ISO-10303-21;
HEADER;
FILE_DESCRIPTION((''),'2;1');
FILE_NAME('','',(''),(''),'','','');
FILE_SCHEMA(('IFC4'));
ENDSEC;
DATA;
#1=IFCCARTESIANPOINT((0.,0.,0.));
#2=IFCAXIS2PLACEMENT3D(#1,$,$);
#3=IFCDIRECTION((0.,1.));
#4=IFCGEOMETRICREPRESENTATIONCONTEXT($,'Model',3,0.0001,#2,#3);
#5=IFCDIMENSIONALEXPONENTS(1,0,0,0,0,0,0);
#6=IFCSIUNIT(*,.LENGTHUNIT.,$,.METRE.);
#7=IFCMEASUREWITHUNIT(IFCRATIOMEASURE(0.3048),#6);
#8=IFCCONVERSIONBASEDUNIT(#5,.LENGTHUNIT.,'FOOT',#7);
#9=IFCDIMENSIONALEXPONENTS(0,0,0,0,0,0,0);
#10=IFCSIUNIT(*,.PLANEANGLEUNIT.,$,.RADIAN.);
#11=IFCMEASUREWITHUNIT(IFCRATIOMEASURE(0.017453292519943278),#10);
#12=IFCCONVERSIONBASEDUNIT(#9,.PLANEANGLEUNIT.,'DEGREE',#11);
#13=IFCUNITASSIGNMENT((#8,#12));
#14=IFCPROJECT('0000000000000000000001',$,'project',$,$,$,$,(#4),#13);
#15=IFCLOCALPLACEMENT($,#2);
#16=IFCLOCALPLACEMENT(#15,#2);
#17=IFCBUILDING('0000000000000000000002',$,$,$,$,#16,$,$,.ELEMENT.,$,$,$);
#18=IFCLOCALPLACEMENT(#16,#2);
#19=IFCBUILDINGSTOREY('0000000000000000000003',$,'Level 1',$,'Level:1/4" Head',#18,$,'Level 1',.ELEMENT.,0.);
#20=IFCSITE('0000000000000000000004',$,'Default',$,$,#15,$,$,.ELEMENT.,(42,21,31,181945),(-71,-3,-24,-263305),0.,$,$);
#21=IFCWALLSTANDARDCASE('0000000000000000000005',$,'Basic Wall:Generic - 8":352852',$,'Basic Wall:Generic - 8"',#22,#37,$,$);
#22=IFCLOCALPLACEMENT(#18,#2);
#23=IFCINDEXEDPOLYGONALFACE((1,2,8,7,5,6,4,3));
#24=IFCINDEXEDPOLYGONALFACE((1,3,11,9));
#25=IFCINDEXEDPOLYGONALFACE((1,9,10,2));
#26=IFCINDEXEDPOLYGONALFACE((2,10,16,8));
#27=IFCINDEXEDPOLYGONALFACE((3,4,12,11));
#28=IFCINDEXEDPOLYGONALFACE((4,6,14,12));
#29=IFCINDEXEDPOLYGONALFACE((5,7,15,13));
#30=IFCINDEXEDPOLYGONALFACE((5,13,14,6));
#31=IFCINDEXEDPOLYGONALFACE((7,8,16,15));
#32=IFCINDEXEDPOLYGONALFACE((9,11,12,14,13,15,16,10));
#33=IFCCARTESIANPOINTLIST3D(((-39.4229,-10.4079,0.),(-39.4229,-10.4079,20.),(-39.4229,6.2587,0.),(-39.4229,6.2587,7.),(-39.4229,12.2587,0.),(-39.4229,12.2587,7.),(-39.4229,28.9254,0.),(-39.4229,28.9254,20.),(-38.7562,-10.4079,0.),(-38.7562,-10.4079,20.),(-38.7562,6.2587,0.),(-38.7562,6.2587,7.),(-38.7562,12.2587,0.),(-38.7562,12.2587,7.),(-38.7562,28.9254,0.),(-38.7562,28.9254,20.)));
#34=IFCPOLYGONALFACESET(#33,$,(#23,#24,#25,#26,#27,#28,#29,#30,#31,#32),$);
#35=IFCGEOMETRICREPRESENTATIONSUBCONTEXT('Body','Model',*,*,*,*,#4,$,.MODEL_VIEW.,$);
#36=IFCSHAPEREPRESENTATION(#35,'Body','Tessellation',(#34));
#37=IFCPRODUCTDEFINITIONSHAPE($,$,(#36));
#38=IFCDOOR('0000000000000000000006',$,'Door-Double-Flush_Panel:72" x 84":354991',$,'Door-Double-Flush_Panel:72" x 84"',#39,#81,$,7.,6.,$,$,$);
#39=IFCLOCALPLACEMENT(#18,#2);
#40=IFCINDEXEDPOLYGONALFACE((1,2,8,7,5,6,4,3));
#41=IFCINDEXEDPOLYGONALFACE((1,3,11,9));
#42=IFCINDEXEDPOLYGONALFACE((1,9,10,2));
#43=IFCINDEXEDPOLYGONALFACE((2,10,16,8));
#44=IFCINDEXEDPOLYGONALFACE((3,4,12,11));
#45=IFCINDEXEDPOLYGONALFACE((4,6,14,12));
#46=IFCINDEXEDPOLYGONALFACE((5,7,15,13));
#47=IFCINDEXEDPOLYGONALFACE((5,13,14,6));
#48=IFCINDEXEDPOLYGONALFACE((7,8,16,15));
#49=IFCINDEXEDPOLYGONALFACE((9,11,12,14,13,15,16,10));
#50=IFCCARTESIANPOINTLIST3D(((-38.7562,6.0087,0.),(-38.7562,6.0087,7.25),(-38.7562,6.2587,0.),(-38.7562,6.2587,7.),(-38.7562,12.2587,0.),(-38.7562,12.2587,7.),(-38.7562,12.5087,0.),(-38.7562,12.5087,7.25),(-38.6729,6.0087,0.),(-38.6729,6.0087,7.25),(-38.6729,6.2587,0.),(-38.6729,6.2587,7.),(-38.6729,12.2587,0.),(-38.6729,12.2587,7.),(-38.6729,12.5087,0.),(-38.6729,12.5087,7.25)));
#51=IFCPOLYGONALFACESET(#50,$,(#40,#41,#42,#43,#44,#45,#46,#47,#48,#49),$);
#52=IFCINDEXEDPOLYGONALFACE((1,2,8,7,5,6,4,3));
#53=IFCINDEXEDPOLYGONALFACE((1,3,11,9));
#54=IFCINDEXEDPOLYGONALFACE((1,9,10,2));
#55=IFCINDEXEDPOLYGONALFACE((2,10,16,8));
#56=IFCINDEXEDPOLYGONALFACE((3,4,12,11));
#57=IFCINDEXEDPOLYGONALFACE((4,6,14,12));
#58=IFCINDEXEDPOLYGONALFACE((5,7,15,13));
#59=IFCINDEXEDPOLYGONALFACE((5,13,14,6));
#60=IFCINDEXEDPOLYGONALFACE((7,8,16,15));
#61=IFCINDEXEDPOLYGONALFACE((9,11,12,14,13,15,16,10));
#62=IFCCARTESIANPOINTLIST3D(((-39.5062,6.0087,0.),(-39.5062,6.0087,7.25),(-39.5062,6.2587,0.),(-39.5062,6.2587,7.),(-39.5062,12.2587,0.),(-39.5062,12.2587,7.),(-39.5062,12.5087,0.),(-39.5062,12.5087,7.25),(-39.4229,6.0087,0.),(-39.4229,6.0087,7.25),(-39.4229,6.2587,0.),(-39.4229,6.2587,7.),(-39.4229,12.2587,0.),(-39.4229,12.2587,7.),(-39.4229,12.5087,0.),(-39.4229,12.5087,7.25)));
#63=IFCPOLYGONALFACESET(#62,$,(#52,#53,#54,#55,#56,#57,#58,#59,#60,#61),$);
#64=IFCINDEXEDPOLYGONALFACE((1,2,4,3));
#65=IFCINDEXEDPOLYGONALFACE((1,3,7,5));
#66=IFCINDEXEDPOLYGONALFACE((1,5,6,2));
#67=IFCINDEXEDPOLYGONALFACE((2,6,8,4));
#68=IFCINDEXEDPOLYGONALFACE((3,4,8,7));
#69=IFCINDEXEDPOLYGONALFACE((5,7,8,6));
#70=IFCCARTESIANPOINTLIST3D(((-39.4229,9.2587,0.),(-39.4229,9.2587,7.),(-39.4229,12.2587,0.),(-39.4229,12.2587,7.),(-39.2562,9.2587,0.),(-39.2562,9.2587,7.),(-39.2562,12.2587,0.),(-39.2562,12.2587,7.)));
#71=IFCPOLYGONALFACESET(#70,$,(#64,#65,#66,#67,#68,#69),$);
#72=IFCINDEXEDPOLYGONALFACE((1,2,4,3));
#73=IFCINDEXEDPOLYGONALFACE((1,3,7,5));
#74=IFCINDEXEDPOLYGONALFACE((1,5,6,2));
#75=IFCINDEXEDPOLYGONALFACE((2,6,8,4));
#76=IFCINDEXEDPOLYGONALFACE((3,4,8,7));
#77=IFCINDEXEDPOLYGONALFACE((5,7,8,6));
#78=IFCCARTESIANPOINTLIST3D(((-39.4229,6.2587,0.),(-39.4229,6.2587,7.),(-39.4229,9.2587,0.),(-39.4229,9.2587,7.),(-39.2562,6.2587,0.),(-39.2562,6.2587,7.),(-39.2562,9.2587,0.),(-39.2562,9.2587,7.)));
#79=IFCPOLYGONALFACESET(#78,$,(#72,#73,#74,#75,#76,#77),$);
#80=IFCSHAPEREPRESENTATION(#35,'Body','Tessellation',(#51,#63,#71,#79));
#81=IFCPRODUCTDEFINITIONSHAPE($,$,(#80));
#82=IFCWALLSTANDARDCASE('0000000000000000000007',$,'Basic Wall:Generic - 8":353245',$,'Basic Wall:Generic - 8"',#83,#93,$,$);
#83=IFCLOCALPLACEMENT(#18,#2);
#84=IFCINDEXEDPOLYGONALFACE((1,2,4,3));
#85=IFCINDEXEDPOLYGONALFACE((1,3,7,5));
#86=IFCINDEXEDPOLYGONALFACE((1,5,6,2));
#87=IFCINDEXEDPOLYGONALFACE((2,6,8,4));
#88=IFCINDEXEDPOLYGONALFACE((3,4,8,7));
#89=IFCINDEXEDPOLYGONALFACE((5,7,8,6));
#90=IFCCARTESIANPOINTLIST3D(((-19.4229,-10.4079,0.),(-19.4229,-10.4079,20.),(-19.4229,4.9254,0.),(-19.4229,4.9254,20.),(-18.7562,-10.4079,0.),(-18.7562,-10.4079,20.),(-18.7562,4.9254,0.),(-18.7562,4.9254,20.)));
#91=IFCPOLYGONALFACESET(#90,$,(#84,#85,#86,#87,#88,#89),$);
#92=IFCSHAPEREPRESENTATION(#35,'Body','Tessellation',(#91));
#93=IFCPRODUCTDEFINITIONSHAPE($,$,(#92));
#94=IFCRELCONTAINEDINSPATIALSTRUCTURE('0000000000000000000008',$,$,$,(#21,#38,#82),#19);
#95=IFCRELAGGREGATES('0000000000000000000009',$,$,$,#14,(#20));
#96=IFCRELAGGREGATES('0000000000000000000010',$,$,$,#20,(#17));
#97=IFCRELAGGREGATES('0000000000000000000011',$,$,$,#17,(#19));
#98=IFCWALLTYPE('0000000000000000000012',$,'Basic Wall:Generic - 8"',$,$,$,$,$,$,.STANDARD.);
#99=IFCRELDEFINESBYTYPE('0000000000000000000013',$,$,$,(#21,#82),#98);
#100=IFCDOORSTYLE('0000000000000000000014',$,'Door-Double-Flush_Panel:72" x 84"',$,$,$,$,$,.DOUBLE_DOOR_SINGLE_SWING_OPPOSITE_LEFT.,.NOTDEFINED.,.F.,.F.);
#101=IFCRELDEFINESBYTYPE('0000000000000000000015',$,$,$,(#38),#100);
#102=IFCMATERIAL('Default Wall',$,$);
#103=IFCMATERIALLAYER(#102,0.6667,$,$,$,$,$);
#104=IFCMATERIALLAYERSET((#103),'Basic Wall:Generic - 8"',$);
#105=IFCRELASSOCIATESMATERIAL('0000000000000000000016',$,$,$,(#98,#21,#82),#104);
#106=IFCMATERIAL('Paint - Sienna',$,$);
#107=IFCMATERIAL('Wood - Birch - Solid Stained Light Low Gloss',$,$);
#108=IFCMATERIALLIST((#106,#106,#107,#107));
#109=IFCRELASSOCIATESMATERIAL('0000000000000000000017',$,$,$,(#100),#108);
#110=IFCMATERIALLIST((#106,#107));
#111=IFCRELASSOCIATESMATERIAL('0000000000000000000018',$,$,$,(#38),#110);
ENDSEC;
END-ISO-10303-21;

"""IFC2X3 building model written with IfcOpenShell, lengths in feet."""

from ifc_helpers import new_model, entity, si_unit, converted_unit, direction, frame, frame_2d, origin, place, context, subcontext, project, spatial, polyline, rectangle, outline, extrude, source, transform, mapped, material, material_list, layer, layer_set, layer_usage, type_object, type_shapes, element, fill, save


model = new_model("IFC2X3")

# Units and contexts
model_context = context("Model", 3, precision=0.0001, world=origin(), true_north=direction((0.0, 1.0)))
body_context = subcontext(model_context, "Body", "Model", "MODEL_VIEW")
ifc_project = project(units=[converted_unit("LENGTHUNIT", "FOOT", entity("IfcRatioMeasure", 0.3048), si_unit("LENGTHUNIT", "METRE"), dimensions=[1, 0, 0, 0, 0, 0, 0]), converted_unit("PLANEANGLEUNIT", "DEGREE", entity("IfcRatioMeasure", 0.017453292519943278), si_unit("PLANEANGLEUNIT", "RADIAN"), dimensions=[0, 0, 0, 0, 0, 0, 0])], contexts=[model_context])

# Site, building, storey
site_placement = place(None, origin())
site = spatial("IfcSite", under=ifc_project, at=site_placement, Name="Default", CompositionType="ELEMENT", RefLatitude=(42, 21, 31, 181945), RefLongitude=(-71, -3, -24, -263305), RefElevation=0.0)
building_placement = place(site_placement, origin())
building = spatial("IfcBuilding", under=site, at=building_placement, CompositionType="ELEMENT")
storey_placement = place(building_placement, origin())
storey = spatial("IfcBuildingStorey", under=building, at=storey_placement, Name="Level 1", ObjectType="Level:1/4\" Head", LongName="Level 1", CompositionType="ELEMENT", Elevation=0.0)

# Shared definitions
ifc_material_1 = material(Name="Default Wall")
ifc_layer = layer(ifc_material_1, 0.6667)
ifc_layer_set = layer_set([ifc_layer], Name="Basic Wall:Generic - 8\"")
wall_type = type_object("IfcWallType", Name="Basic Wall:Generic - 8\"", PredefinedType="STANDARD", material=ifc_layer_set)

# Wall, opening, door
ifc_layer_usage_1 = layer_usage(ifc_layer_set, "AXIS2", "NEGATIVE", 0.3333)
wall_1_placement = place(storey_placement, frame((-39.0895, -10.4079, 0.0), z_axis=(0.0, 0.0, 1.0), x_axis=(0.0, 1.0, 0.0)))
wall_1 = element("IfcWallStandardCase", 1, at=wall_1_placement, inside=storey, type_object=wall_type, material=ifc_layer_usage_1, Name="Basic Wall:Generic - 8\":352852", ObjectType="Basic Wall:Generic - 8\"", context=body_context, shape_type="SweptSolid", body=[
    extrude(rectangle(XDim=39.3333, YDim=0.6667, at=frame_2d((19.6667, 0.0), x_axis=(1.0, 0.0))), origin(), (0.0, 0.0, 1.0), 20.0),
])
opening_1_placement = place(wall_1_placement, frame((16.6667, -0.3333, 0.0)))
opening_1 = element("IfcOpeningElement", 2, at=opening_1_placement, cuts=wall_1, ObjectType="Opening", context=body_context, shape_type="SweptSolid", body=[
    extrude(rectangle(XDim=7.0, YDim=6.0, at=frame_2d((3.5, 3.0), x_axis=(1.0, 0.0))), frame((0.0, 0.0, 0.0), z_axis=(0.0, 1.0, 0.0), x_axis=(0.0, 0.0, 1.0)), (0.0, 0.0, 1.0), 0.6667),
])
ifc_material_2 = material(Name="Paint - Sienna")
ifc_material_3 = material(Name="Wood - Birch - Solid Stained Light Low Gloss")
ifc_material_list_1 = material_list([ifc_material_2, ifc_material_3])
ifc_material_list_2 = material_list([ifc_material_2, ifc_material_2, ifc_material_3, ifc_material_3])
door_style_1 = type_object("IfcDoorStyle", Name="Door-Double-Flush_Panel:72\" x 84\"", ConstructionType="NOTDEFINED", OperationType="DOUBLE_DOOR_SINGLE_SWING_OPPOSITE_LEFT", ParameterTakesPrecedence=False, Sizeable=False, material=ifc_material_list_2)
shared_shape_1 = source(origin(), body_context, "Body", "SweptSolid", [
    extrude(outline(polyline([(-3.4375, 3.0), (3.5625, 3.0), (3.5625, 3.25), (-3.6875, 3.25), (-3.6875, -3.25), (3.5625, -3.25), (3.5625, -3.0), (-3.4375, -3.0), (-3.4375, 3.0)])), frame((3.0, -0.0833, 3.5625), z_axis=(0.0, 1.0, 0.0), x_axis=(0.0, 0.0, -1.0)), (0.0, 0.0, 1.0), 0.0833),
    extrude(outline(polyline([(-3.4375, 3.0), (3.5625, 3.0), (3.5625, 3.25), (-3.6875, 3.25), (-3.6875, -3.25), (3.5625, -3.25), (3.5625, -3.0), (-3.4375, -3.0), (-3.4375, 3.0)])), frame((3.0, 0.6667, 3.5625), z_axis=(0.0, 1.0, 0.0), x_axis=(0.0, 0.0, -1.0)), (0.0, 0.0, 1.0), 0.0833),
    extrude(rectangle(XDim=0.1667, YDim=3.0, at=frame_2d((0.0, 0.0), x_axis=(1.0, 0.0))), frame((4.5, 0.5833, 0.0), z_axis=(0.0, 0.0, 1.0), x_axis=(0.0, -1.0, 0.0)), (0.0, 0.0, 1.0), 7.0),
    extrude(rectangle(XDim=0.1667, YDim=3.0, at=frame_2d((0.0, 0.0), x_axis=(1.0, 0.0))), frame((1.5, 0.5833, 0.0), z_axis=(0.0, 0.0, 1.0), x_axis=(0.0, -1.0, 0.0)), (0.0, 0.0, 1.0), 7.0),
])
type_shapes(door_style_1, [shared_shape_1])
door_1_placement = place(opening_1_placement, origin())
door_1 = element("IfcDoor", 3, at=door_1_placement, inside=storey, type_object=door_style_1, material=ifc_material_list_1, Name="Door-Double-Flush_Panel:72\" x 84\":354991", ObjectType="Door-Double-Flush_Panel:72\" x 84\"", OverallHeight=7.0, OverallWidth=6.0, context=body_context, shape_type="MappedRepresentation", body=[
    mapped(shared_shape_1, transform((0.0, 0.0, 0.0), scale=1.0)),
])
fill(opening_1, door_1)

# Wall
ifc_layer_usage_2 = layer_usage(ifc_layer_set, "AXIS2", "NEGATIVE", 0.3333)
wall_2_placement = place(storey_placement, frame((-19.0895, 4.9254, 0.0), z_axis=(0.0, 0.0, 1.0), x_axis=(0.0, -1.0, 0.0)))
element("IfcWallStandardCase", 4, at=wall_2_placement, inside=storey, type_object=wall_type, material=ifc_layer_usage_2, Name="Basic Wall:Generic - 8\":353245", ObjectType="Basic Wall:Generic - 8\"", context=body_context, shape_type="SweptSolid", body=[
    extrude(rectangle(XDim=15.3333, YDim=0.6667, at=frame_2d((7.6667, 0.0), x_axis=(-1.0, 0.0))), origin(), (0.0, 0.0, 1.0), 20.0),
])

save(model, "model.ifc")
